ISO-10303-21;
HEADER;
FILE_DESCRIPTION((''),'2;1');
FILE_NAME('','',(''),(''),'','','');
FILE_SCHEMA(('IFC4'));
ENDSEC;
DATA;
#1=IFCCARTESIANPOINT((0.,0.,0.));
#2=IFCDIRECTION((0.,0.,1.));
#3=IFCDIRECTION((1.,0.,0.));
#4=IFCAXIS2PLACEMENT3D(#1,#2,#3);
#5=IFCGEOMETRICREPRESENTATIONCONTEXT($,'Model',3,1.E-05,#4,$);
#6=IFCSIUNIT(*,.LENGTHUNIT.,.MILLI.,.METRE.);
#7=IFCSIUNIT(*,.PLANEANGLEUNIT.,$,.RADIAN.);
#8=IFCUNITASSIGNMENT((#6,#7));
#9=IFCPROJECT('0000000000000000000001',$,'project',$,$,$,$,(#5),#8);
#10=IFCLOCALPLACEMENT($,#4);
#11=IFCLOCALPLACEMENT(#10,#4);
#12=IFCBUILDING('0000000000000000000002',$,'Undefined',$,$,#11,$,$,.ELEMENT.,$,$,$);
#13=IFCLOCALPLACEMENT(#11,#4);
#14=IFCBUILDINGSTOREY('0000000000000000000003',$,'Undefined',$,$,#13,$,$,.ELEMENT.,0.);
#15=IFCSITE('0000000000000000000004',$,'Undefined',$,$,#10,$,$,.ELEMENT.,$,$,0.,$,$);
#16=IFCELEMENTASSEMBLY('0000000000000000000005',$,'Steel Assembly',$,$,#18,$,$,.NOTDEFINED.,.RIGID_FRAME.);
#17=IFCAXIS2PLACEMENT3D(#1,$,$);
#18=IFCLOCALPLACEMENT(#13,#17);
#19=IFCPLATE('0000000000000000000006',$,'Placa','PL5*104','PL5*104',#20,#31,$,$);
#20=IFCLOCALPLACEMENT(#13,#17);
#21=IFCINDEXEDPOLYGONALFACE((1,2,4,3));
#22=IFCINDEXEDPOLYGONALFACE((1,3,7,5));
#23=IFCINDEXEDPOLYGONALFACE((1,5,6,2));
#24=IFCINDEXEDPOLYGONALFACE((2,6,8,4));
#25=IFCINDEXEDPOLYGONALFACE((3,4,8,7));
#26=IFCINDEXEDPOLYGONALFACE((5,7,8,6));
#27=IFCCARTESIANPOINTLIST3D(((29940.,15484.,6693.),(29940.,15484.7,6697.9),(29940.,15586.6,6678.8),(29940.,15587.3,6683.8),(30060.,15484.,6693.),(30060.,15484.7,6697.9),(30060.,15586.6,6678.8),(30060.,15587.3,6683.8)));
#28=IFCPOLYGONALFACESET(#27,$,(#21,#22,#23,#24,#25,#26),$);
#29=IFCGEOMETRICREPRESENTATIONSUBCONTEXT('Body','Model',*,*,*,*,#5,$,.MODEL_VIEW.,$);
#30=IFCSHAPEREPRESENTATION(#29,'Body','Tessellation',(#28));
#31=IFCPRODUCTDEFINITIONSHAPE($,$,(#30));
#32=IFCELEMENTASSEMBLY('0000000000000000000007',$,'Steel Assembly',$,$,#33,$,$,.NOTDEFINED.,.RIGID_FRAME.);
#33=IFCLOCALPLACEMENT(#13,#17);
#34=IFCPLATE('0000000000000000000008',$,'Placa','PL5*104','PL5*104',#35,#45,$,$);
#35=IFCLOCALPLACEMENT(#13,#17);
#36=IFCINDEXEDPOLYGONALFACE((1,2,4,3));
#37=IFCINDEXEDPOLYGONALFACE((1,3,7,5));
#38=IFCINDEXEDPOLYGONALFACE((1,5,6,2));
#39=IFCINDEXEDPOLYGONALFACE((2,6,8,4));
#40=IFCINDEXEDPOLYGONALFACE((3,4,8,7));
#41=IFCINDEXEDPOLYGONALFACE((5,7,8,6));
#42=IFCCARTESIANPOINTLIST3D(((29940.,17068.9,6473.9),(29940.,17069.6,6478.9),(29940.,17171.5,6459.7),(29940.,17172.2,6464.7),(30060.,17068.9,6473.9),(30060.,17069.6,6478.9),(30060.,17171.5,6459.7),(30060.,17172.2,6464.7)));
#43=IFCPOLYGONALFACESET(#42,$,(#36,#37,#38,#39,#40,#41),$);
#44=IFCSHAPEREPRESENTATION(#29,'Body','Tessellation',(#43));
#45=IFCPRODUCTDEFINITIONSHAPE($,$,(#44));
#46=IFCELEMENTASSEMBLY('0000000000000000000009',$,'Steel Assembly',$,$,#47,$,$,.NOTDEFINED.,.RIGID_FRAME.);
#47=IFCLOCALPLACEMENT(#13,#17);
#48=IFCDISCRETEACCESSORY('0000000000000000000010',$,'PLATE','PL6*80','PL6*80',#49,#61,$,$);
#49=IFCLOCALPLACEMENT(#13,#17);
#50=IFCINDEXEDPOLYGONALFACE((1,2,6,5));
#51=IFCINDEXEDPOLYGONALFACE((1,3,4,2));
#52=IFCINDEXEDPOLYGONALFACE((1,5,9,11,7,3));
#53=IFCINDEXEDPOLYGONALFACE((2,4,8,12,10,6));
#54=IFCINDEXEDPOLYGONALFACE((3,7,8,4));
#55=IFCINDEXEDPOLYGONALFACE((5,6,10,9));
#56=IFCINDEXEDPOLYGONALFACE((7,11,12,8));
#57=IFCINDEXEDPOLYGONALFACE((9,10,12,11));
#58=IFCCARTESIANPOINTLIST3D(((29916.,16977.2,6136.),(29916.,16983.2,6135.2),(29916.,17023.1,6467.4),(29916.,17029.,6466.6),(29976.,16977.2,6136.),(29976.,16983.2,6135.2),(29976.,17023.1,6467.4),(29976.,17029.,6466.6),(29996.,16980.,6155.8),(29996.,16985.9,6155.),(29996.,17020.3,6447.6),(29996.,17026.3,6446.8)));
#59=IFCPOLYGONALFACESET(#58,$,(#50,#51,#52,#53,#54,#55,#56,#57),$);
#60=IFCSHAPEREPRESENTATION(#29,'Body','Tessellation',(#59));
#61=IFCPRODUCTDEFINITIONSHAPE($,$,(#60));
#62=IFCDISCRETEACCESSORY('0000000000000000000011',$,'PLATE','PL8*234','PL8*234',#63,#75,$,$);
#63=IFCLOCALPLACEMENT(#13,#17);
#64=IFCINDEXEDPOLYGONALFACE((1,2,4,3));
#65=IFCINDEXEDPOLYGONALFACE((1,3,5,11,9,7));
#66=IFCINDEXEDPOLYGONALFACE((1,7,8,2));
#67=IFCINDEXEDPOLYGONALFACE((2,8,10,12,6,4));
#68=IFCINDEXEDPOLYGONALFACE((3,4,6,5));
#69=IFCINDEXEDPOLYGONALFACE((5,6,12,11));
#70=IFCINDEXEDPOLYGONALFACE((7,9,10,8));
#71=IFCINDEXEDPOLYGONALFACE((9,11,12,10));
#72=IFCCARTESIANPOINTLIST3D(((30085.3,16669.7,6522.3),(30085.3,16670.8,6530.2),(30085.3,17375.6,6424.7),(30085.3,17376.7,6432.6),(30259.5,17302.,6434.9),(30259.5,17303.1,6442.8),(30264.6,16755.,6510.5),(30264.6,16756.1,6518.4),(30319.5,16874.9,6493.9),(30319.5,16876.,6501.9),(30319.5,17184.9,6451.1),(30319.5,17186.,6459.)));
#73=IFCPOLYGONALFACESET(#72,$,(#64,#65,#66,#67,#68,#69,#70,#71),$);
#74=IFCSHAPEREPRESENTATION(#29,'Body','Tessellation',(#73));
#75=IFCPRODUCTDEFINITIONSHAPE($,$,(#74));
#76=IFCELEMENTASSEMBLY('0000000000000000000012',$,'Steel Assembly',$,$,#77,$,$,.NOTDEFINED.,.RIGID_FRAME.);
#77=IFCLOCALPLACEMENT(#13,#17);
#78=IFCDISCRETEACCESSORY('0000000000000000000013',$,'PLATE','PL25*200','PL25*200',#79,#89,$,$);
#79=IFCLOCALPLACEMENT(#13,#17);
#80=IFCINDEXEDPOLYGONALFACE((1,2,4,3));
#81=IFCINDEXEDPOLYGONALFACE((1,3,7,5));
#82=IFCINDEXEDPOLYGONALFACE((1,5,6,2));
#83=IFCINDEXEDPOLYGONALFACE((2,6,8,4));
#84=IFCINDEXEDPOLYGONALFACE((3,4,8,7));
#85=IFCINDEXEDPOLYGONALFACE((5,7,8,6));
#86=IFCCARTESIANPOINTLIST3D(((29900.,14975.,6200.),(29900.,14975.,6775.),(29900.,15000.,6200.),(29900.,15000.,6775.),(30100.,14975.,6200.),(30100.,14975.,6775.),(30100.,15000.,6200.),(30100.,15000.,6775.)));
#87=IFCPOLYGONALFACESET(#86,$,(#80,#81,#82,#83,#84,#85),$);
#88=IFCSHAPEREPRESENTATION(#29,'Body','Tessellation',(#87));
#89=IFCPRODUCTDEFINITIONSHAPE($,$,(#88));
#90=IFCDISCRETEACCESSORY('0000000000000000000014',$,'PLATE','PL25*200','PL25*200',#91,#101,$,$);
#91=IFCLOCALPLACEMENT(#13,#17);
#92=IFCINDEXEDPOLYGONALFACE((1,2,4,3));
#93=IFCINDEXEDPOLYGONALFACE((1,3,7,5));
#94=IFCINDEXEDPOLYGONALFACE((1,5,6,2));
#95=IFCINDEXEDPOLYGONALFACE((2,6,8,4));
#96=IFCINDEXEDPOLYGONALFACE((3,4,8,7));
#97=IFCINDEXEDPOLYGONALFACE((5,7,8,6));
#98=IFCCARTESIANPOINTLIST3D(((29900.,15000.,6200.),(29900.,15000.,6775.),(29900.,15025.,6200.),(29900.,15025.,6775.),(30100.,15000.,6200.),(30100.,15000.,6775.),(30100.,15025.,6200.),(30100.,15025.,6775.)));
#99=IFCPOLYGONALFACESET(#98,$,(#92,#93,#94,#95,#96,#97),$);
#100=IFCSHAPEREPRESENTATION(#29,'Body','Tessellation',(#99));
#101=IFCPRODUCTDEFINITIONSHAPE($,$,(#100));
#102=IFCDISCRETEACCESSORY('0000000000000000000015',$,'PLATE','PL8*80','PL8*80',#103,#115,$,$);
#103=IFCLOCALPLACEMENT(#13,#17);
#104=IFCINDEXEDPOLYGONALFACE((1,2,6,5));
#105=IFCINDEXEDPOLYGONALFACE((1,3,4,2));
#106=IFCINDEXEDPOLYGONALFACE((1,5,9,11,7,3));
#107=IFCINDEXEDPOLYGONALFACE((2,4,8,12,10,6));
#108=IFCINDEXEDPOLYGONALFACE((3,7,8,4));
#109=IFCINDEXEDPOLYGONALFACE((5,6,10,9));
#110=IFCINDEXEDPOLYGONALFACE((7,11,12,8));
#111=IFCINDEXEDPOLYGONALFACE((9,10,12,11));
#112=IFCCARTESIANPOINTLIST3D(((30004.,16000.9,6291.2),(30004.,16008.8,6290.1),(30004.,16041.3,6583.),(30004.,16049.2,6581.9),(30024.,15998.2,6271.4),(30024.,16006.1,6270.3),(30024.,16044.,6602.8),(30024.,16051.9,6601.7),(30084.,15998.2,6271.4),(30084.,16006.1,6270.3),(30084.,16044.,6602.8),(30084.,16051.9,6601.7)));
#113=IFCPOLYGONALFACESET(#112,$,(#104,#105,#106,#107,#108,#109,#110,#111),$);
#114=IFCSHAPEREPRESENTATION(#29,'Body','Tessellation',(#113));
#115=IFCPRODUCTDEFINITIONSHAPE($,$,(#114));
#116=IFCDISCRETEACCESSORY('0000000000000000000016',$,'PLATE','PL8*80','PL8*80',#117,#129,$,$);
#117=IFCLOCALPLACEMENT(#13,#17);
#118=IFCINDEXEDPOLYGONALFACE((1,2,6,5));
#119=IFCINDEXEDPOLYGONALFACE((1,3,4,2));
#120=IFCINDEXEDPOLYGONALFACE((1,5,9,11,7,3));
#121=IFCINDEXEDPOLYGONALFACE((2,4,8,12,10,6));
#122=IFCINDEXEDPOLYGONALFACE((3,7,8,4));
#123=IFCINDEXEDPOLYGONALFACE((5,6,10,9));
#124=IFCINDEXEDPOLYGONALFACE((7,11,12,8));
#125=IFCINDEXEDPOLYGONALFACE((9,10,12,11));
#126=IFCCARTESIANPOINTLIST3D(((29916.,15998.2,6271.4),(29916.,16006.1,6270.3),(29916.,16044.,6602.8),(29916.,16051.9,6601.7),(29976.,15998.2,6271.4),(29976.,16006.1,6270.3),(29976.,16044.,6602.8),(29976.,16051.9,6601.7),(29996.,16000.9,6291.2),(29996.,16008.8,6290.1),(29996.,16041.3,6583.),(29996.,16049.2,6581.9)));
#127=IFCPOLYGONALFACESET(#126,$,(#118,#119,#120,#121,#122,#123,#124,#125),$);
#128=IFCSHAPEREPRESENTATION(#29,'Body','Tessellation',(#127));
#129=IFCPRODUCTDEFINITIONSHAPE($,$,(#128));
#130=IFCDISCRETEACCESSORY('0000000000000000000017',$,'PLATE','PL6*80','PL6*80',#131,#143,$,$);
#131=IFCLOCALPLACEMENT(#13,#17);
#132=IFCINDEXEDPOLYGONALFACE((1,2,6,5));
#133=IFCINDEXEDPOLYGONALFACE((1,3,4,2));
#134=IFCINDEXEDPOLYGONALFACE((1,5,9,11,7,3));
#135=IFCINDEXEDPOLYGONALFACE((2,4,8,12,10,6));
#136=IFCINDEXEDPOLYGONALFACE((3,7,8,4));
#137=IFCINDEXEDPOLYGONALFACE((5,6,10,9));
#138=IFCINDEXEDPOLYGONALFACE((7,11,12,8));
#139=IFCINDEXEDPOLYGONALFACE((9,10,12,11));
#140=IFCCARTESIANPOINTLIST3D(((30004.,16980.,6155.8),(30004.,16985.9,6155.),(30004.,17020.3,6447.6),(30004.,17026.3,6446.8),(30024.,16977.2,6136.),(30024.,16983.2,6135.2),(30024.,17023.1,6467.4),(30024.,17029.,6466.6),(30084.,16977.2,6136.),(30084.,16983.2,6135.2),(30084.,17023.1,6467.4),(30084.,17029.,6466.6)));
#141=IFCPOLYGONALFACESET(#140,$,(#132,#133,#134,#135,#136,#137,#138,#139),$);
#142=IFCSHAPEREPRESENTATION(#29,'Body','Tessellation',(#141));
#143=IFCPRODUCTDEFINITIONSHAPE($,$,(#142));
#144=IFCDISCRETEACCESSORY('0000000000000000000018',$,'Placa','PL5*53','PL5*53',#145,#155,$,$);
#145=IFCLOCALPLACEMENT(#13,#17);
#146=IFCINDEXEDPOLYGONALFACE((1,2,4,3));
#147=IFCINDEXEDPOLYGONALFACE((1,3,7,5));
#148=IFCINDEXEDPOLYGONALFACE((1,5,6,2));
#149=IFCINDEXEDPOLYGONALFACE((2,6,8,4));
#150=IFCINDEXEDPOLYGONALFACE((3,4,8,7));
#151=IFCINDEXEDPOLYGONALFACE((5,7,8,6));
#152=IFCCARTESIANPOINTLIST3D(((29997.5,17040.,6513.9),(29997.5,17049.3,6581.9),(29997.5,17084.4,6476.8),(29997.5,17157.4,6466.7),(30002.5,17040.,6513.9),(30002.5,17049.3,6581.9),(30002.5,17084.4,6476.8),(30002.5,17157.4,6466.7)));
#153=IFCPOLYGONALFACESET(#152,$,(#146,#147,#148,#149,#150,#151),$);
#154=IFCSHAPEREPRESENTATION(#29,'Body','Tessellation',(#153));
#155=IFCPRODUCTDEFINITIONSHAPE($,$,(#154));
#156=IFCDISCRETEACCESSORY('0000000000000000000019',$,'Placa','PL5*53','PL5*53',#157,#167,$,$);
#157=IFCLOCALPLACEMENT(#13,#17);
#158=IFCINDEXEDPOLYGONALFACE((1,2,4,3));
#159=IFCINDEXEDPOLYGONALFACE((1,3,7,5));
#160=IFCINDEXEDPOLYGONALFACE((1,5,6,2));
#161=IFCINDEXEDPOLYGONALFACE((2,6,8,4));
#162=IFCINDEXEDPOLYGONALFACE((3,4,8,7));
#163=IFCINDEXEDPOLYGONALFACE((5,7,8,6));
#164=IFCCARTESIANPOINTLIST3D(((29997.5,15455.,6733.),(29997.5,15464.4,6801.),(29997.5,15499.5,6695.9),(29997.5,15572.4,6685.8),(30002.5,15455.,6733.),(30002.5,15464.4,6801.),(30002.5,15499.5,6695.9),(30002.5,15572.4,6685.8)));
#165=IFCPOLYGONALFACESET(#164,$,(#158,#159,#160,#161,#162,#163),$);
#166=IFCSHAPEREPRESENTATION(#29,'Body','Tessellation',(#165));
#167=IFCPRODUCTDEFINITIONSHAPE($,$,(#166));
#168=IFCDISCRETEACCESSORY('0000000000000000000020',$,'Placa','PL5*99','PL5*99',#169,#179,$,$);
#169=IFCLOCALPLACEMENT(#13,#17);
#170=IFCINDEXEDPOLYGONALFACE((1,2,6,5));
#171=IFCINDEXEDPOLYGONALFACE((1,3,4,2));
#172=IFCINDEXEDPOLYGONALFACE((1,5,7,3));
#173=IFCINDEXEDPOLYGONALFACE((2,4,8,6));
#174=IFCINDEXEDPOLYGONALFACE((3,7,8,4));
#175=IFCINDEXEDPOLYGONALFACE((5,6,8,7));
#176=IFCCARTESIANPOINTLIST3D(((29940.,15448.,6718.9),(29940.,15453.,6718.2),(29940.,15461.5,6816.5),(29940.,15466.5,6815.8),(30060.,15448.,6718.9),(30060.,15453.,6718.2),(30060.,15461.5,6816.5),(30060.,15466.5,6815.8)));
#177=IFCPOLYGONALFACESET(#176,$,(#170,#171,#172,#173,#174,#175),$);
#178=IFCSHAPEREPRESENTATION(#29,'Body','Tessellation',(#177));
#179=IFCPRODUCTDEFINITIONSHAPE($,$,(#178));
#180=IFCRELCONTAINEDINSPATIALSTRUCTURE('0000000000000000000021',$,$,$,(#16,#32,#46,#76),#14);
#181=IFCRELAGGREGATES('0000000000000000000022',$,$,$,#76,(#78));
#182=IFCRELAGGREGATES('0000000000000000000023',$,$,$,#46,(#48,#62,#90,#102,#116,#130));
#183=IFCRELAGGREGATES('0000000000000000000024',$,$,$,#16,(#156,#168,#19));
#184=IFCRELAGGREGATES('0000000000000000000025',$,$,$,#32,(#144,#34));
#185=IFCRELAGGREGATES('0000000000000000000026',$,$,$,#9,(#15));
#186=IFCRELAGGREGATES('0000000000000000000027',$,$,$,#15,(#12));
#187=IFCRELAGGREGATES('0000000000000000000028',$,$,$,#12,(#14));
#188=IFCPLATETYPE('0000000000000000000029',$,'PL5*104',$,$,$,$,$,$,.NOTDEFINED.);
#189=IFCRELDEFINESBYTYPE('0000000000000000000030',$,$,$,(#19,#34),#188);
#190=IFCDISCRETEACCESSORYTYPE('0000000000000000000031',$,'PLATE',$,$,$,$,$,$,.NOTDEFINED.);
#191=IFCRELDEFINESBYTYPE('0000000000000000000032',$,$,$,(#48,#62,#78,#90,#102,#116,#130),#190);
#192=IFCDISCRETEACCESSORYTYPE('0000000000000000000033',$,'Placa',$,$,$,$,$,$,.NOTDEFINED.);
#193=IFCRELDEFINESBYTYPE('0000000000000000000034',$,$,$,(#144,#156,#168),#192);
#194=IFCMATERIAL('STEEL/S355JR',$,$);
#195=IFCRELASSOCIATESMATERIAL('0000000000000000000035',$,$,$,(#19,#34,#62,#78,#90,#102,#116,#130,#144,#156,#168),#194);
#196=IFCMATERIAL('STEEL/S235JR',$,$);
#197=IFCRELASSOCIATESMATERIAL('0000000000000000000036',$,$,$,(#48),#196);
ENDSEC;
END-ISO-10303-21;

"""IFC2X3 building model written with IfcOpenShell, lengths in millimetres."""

from ifc_helpers import new_model, si_unit, frame, origin_with_axes, place, context, subcontext, project, spatial, polyline, outline, extrude, material, type_object, element, aggregate, save


model = new_model("IFC2X3")

# Units and contexts
model_context = context("Model", 3, precision=1e-05, world=origin_with_axes())
body_context = subcontext(model_context, "Body", "Model", "MODEL_VIEW")
ifc_project = project(units=[si_unit("LENGTHUNIT", "METRE", prefix="MILLI"), si_unit("PLANEANGLEUNIT", "RADIAN")], contexts=[model_context])

# Site, building, storey
site_placement = place(None, origin_with_axes())
site = spatial("IfcSite", under=ifc_project, at=site_placement, Name="Undefined", CompositionType="ELEMENT", RefElevation=0.0)
building_placement = place(site_placement, origin_with_axes())
building = spatial("IfcBuilding", under=site, at=building_placement, Name="Undefined", CompositionType="ELEMENT")
storey_placement = place(building_placement, origin_with_axes())
storey = spatial("IfcBuildingStorey", under=building, at=storey_placement, Name="Undefined", CompositionType="ELEMENT", Elevation=0.0)

# Shared definitions
ifc_material_1 = material(Name="STEEL/S355JR")

# Element assemblies, plates
assembly_1_placement = place(storey_placement, origin_with_axes())
assembly_1 = element("IfcElementAssembly", 1, at=assembly_1_placement, inside=storey, Name="Steel Assembly", AssemblyPlace="NOTDEFINED", PredefinedType="RIGID_FRAME")
plate_type = type_object("IfcPlateType", Name="PL5*104", PredefinedType="NOTDEFINED")
plate_1_placement = place(assembly_1_placement, frame((29940.0, 15484.3, 6695.5), z_axis=(0.0, -0.136905, -0.990584), x_axis=(0.0, 0.990584, -0.136905)))
plate_1 = element("IfcPlate", 2, at=plate_1_placement, type_object=plate_type, material=ifc_material_1, Name="Placa", Description="PL5*104", ObjectType="PL5*104", context=body_context, shape_type="SweptSolid", body=[
    extrude(outline(polyline([(0.0, 0.0), (103.6, 0.0), (103.6, 120.0), (0.0, 120.0), (0.0, 0.0)])), frame((0.0, 0.0, -2.5), z_axis=(0.0, 0.0, 1.0), x_axis=(1.0, 0.0, 0.0)), (0.0, 0.0, 1.0), 5.0),
])
assembly_2_placement = place(storey_placement, origin_with_axes())
assembly_2 = element("IfcElementAssembly", 3, at=assembly_2_placement, inside=storey, Name="Steel Assembly", AssemblyPlace="NOTDEFINED", PredefinedType="RIGID_FRAME")
plate_2_placement = place(assembly_2_placement, frame((29940.0, 17069.2, 6476.4), z_axis=(0.0, -0.136905, -0.990584), x_axis=(0.0, 0.990584, -0.136905)))
plate_2 = element("IfcPlate", 4, at=plate_2_placement, type_object=plate_type, material=ifc_material_1, Name="Placa", Description="PL5*104", ObjectType="PL5*104", context=body_context, shape_type="SweptSolid", body=[
    extrude(outline(polyline([(0.0, 0.0), (103.6, 0.0), (103.6, 120.0), (0.0, 120.0), (0.0, 0.0)])), frame((0.0, 0.0, -2.5), z_axis=(0.0, 0.0, 1.0), x_axis=(1.0, 0.0, 0.0)), (0.0, 0.0, 1.0), 5.0),
])

# Element assembly, discrete accessories
assembly_3_placement = place(storey_placement, origin_with_axes())
assembly_3 = element("IfcElementAssembly", 5, at=assembly_3_placement, inside=storey, Name="Steel Assembly", AssemblyPlace="NOTDEFINED", PredefinedType="RIGID_FRAME")
ifc_material_2 = material(Name="STEEL/S235JR")
discrete_accessory_type_1 = type_object("IfcDiscreteAccessoryType", Name="PLATE")
discrete_accessory_1_placement = place(assembly_3_placement, frame((29996.0, 16980.2, 6135.6), z_axis=(0.0, 0.990574, -0.13698), x_axis=(-1.0, 0.0, 0.0)))
discrete_accessory_1 = element("IfcDiscreteAccessory", 6, at=discrete_accessory_1_placement, type_object=discrete_accessory_type_1, material=ifc_material_2, Name="PLATE", Description="PL6*80", ObjectType="PL6*80", context=body_context, shape_type="SweptSolid", body=[
    extrude(outline(polyline([(0.0, 20.0), (20.0, 0.0), (80.0, 0.0), (80.0, 334.6), (20.0, 334.6), (0.0, 314.6), (0.0, 20.0)])), frame((0.0, 0.0, -3.0), z_axis=(0.0, 0.0, 1.0), x_axis=(1.0, 0.0, 0.0)), (0.0, 0.0, 1.0), 6.0),
])
discrete_accessory_2_placement = place(assembly_3_placement, frame((30085.3, 16670.3, 6526.3), z_axis=(0.000018, -0.13698, -0.990574), x_axis=(0.0, 0.990574, -0.13698)))
discrete_accessory_2 = element("IfcDiscreteAccessory", 7, at=discrete_accessory_2_placement, type_object=discrete_accessory_type_1, material=ifc_material_1, Name="PLATE", Description="PL8*234", ObjectType="PL8*234", context=body_context, shape_type="SweptSolid", body=[
    extrude(outline(polyline([(0.0, 0.0), (712.6, 0.0), (638.3, 174.2), (520.1, 234.3), (207.1, 234.3), (86.0, 179.4), (0.0, 0.0)])), frame((0.0, 0.0, -4.0), z_axis=(0.0, 0.0, 1.0), x_axis=(1.0, 0.0, 0.0)), (0.0, 0.0, 1.0), 8.0),
])

# Element assembly, discrete accessory
assembly_4_placement = place(storey_placement, origin_with_axes())
assembly_4 = element("IfcElementAssembly", 8, at=assembly_4_placement, inside=storey, Name="Steel Assembly", AssemblyPlace="NOTDEFINED", PredefinedType="RIGID_FRAME")
discrete_accessory_3_placement = place(assembly_4_placement, frame((30000.0, 14987.5, 6775.0), z_axis=(0.0, -1.0, 0.0), x_axis=(0.0, 0.0, -1.0)))
discrete_accessory_3 = element("IfcDiscreteAccessory", 9, at=discrete_accessory_3_placement, type_object=discrete_accessory_type_1, material=ifc_material_1, Name="PLATE", Description="PL25*200", ObjectType="PL25*200", context=body_context, shape_type="SweptSolid", body=[
    extrude(outline(polyline([(575.0, -100.0), (0.0, -100.0), (0.0, 100.0), (575.0, 100.0), (575.0, -100.0)])), frame((0.0, 0.0, -12.5), z_axis=(0.0, 0.0, 1.0), x_axis=(1.0, 0.0, 0.0)), (0.0, 0.0, 1.0), 25.0),
])
aggregate(assembly_4, [discrete_accessory_3])

# Discrete accessories
discrete_accessory_4_placement = place(assembly_3_placement, frame((30000.0, 15012.5, 6775.0), z_axis=(0.0, -1.0, 0.0), x_axis=(0.0, 0.0, -1.0)))
discrete_accessory_4 = element("IfcDiscreteAccessory", 10, at=discrete_accessory_4_placement, type_object=discrete_accessory_type_1, material=ifc_material_1, Name="PLATE", Description="PL25*200", ObjectType="PL25*200", context=body_context, shape_type="SweptSolid", body=[
    extrude(outline(polyline([(575.0, -100.0), (0.0, -100.0), (0.0, 100.0), (575.0, 100.0), (575.0, -100.0)])), frame((0.0, 0.0, -12.5), z_axis=(0.0, 0.0, 1.0), x_axis=(1.0, 0.0, 0.0)), (0.0, 0.0, 1.0), 25.0),
])
discrete_accessory_5_placement = place(assembly_3_placement, frame((30084.0, 16002.1, 6270.8), z_axis=(0.0, 0.990574, -0.13698), x_axis=(-1.0, 0.0, 0.0)))
discrete_accessory_5 = element("IfcDiscreteAccessory", 11, at=discrete_accessory_5_placement, type_object=discrete_accessory_type_1, material=ifc_material_1, Name="PLATE", Description="PL8*80", ObjectType="PL8*80", context=body_context, shape_type="SweptSolid", body=[
    extrude(outline(polyline([(0.0, 0.0), (60.0, 0.0), (80.0, 20.0), (80.0, 314.6), (60.0, 334.6), (0.0, 334.6), (0.0, 0.0)])), frame((0.0, 0.0, -4.0), z_axis=(0.0, 0.0, 1.0), x_axis=(1.0, 0.0, 0.0)), (0.0, 0.0, 1.0), 8.0),
])
discrete_accessory_6_placement = place(assembly_3_placement, frame((29996.0, 16002.1, 6270.8), z_axis=(0.0, 0.990574, -0.13698), x_axis=(-1.0, 0.0, 0.0)))
discrete_accessory_6 = element("IfcDiscreteAccessory", 12, at=discrete_accessory_6_placement, type_object=discrete_accessory_type_1, material=ifc_material_1, Name="PLATE", Description="PL8*80", ObjectType="PL8*80", context=body_context, shape_type="SweptSolid", body=[
    extrude(outline(polyline([(0.0, 20.0), (20.0, 0.0), (80.0, 0.0), (80.0, 334.6), (20.0, 334.6), (0.0, 314.6), (0.0, 20.0)])), frame((0.0, 0.0, -4.0), z_axis=(0.0, 0.0, 1.0), x_axis=(1.0, 0.0, 0.0)), (0.0, 0.0, 1.0), 8.0),
])
discrete_accessory_7_placement = place(assembly_3_placement, frame((30084.0, 16980.2, 6135.6), z_axis=(0.0, 0.990574, -0.13698), x_axis=(-1.0, 0.0, 0.0)))
discrete_accessory_7 = element("IfcDiscreteAccessory", 13, at=discrete_accessory_7_placement, type_object=discrete_accessory_type_1, material=ifc_material_1, Name="PLATE", Description="PL6*80", ObjectType="PL6*80", context=body_context, shape_type="SweptSolid", body=[
    extrude(outline(polyline([(0.0, 0.0), (60.0, 0.0), (80.0, 20.0), (80.0, 314.6), (60.0, 334.6), (0.0, 334.6), (0.0, 0.0)])), frame((0.0, 0.0, -3.0), z_axis=(0.0, 0.0, 1.0), x_axis=(1.0, 0.0, 0.0)), (0.0, 0.0, 1.0), 6.0),
])
discrete_accessory_type_2 = type_object("IfcDiscreteAccessoryType", Name="Placa")
discrete_accessory_8_placement = place(assembly_2_placement, frame((30000.0, 17049.3, 6581.9), z_axis=(-1.0, 0.0, 0.0), x_axis=(0.0, 0.684057, -0.729429)))
discrete_accessory_8 = element("IfcDiscreteAccessory", 14, at=discrete_accessory_8_placement, type_object=discrete_accessory_type_2, material=ifc_material_1, Name="Placa", Description="PL5*53", ObjectType="PL5*53", context=body_context, shape_type="SweptSolid", body=[
    extrude(outline(polyline([(0.0, 0.0), (157.9, 0.0), (100.7, 46.3), (43.1, 53.3), (0.0, 0.0)])), frame((0.0, 0.0, -2.5), z_axis=(0.0, 0.0, 1.0), x_axis=(1.0, 0.0, 0.0)), (0.0, 0.0, 1.0), 5.0),
])
discrete_accessory_9_placement = place(assembly_1_placement, frame((30000.0, 15464.4, 6801.0), z_axis=(-1.0, 0.0, 0.0), x_axis=(0.0, 0.684057, -0.729429)))
discrete_accessory_9 = element("IfcDiscreteAccessory", 15, at=discrete_accessory_9_placement, type_object=discrete_accessory_type_2, material=ifc_material_1, Name="Placa", Description="PL5*53", ObjectType="PL5*53", context=body_context, shape_type="SweptSolid", body=[
    extrude(outline(polyline([(0.0, 0.0), (157.9, 0.0), (100.7, 46.3), (43.1, 53.3), (0.0, 0.0)])), frame((0.0, 0.0, -2.5), z_axis=(0.0, 0.0, 1.0), x_axis=(1.0, 0.0, 0.0)), (0.0, 0.0, 1.0), 5.0),
])
discrete_accessory_10_placement = place(assembly_1_placement, frame((29940.0, 15450.5, 6718.5), z_axis=(0.0, 0.990592, -0.136849), x_axis=(0.0, 0.136849, 0.990592)))
discrete_accessory_10 = element("IfcDiscreteAccessory", 16, at=discrete_accessory_10_placement, type_object=discrete_accessory_type_2, material=ifc_material_1, Name="Placa", Description="PL5*99", ObjectType="PL5*99", context=body_context, shape_type="SweptSolid", body=[
    extrude(outline(polyline([(0.0, 0.0), (98.6, 0.0), (98.6, 120.0), (0.0, 120.0), (0.0, 0.0)])), frame((0.0, 0.0, -2.5), z_axis=(0.0, 0.0, 1.0), x_axis=(1.0, 0.0, 0.0)), (0.0, 0.0, 1.0), 5.0),
])

aggregate(assembly_3, [discrete_accessory_1, discrete_accessory_2, discrete_accessory_4, discrete_accessory_5, discrete_accessory_6, discrete_accessory_7])

aggregate(assembly_1, [discrete_accessory_9, discrete_accessory_10, plate_1])
aggregate(assembly_2, [discrete_accessory_8, plate_2])

save(model, "model.ifc")
